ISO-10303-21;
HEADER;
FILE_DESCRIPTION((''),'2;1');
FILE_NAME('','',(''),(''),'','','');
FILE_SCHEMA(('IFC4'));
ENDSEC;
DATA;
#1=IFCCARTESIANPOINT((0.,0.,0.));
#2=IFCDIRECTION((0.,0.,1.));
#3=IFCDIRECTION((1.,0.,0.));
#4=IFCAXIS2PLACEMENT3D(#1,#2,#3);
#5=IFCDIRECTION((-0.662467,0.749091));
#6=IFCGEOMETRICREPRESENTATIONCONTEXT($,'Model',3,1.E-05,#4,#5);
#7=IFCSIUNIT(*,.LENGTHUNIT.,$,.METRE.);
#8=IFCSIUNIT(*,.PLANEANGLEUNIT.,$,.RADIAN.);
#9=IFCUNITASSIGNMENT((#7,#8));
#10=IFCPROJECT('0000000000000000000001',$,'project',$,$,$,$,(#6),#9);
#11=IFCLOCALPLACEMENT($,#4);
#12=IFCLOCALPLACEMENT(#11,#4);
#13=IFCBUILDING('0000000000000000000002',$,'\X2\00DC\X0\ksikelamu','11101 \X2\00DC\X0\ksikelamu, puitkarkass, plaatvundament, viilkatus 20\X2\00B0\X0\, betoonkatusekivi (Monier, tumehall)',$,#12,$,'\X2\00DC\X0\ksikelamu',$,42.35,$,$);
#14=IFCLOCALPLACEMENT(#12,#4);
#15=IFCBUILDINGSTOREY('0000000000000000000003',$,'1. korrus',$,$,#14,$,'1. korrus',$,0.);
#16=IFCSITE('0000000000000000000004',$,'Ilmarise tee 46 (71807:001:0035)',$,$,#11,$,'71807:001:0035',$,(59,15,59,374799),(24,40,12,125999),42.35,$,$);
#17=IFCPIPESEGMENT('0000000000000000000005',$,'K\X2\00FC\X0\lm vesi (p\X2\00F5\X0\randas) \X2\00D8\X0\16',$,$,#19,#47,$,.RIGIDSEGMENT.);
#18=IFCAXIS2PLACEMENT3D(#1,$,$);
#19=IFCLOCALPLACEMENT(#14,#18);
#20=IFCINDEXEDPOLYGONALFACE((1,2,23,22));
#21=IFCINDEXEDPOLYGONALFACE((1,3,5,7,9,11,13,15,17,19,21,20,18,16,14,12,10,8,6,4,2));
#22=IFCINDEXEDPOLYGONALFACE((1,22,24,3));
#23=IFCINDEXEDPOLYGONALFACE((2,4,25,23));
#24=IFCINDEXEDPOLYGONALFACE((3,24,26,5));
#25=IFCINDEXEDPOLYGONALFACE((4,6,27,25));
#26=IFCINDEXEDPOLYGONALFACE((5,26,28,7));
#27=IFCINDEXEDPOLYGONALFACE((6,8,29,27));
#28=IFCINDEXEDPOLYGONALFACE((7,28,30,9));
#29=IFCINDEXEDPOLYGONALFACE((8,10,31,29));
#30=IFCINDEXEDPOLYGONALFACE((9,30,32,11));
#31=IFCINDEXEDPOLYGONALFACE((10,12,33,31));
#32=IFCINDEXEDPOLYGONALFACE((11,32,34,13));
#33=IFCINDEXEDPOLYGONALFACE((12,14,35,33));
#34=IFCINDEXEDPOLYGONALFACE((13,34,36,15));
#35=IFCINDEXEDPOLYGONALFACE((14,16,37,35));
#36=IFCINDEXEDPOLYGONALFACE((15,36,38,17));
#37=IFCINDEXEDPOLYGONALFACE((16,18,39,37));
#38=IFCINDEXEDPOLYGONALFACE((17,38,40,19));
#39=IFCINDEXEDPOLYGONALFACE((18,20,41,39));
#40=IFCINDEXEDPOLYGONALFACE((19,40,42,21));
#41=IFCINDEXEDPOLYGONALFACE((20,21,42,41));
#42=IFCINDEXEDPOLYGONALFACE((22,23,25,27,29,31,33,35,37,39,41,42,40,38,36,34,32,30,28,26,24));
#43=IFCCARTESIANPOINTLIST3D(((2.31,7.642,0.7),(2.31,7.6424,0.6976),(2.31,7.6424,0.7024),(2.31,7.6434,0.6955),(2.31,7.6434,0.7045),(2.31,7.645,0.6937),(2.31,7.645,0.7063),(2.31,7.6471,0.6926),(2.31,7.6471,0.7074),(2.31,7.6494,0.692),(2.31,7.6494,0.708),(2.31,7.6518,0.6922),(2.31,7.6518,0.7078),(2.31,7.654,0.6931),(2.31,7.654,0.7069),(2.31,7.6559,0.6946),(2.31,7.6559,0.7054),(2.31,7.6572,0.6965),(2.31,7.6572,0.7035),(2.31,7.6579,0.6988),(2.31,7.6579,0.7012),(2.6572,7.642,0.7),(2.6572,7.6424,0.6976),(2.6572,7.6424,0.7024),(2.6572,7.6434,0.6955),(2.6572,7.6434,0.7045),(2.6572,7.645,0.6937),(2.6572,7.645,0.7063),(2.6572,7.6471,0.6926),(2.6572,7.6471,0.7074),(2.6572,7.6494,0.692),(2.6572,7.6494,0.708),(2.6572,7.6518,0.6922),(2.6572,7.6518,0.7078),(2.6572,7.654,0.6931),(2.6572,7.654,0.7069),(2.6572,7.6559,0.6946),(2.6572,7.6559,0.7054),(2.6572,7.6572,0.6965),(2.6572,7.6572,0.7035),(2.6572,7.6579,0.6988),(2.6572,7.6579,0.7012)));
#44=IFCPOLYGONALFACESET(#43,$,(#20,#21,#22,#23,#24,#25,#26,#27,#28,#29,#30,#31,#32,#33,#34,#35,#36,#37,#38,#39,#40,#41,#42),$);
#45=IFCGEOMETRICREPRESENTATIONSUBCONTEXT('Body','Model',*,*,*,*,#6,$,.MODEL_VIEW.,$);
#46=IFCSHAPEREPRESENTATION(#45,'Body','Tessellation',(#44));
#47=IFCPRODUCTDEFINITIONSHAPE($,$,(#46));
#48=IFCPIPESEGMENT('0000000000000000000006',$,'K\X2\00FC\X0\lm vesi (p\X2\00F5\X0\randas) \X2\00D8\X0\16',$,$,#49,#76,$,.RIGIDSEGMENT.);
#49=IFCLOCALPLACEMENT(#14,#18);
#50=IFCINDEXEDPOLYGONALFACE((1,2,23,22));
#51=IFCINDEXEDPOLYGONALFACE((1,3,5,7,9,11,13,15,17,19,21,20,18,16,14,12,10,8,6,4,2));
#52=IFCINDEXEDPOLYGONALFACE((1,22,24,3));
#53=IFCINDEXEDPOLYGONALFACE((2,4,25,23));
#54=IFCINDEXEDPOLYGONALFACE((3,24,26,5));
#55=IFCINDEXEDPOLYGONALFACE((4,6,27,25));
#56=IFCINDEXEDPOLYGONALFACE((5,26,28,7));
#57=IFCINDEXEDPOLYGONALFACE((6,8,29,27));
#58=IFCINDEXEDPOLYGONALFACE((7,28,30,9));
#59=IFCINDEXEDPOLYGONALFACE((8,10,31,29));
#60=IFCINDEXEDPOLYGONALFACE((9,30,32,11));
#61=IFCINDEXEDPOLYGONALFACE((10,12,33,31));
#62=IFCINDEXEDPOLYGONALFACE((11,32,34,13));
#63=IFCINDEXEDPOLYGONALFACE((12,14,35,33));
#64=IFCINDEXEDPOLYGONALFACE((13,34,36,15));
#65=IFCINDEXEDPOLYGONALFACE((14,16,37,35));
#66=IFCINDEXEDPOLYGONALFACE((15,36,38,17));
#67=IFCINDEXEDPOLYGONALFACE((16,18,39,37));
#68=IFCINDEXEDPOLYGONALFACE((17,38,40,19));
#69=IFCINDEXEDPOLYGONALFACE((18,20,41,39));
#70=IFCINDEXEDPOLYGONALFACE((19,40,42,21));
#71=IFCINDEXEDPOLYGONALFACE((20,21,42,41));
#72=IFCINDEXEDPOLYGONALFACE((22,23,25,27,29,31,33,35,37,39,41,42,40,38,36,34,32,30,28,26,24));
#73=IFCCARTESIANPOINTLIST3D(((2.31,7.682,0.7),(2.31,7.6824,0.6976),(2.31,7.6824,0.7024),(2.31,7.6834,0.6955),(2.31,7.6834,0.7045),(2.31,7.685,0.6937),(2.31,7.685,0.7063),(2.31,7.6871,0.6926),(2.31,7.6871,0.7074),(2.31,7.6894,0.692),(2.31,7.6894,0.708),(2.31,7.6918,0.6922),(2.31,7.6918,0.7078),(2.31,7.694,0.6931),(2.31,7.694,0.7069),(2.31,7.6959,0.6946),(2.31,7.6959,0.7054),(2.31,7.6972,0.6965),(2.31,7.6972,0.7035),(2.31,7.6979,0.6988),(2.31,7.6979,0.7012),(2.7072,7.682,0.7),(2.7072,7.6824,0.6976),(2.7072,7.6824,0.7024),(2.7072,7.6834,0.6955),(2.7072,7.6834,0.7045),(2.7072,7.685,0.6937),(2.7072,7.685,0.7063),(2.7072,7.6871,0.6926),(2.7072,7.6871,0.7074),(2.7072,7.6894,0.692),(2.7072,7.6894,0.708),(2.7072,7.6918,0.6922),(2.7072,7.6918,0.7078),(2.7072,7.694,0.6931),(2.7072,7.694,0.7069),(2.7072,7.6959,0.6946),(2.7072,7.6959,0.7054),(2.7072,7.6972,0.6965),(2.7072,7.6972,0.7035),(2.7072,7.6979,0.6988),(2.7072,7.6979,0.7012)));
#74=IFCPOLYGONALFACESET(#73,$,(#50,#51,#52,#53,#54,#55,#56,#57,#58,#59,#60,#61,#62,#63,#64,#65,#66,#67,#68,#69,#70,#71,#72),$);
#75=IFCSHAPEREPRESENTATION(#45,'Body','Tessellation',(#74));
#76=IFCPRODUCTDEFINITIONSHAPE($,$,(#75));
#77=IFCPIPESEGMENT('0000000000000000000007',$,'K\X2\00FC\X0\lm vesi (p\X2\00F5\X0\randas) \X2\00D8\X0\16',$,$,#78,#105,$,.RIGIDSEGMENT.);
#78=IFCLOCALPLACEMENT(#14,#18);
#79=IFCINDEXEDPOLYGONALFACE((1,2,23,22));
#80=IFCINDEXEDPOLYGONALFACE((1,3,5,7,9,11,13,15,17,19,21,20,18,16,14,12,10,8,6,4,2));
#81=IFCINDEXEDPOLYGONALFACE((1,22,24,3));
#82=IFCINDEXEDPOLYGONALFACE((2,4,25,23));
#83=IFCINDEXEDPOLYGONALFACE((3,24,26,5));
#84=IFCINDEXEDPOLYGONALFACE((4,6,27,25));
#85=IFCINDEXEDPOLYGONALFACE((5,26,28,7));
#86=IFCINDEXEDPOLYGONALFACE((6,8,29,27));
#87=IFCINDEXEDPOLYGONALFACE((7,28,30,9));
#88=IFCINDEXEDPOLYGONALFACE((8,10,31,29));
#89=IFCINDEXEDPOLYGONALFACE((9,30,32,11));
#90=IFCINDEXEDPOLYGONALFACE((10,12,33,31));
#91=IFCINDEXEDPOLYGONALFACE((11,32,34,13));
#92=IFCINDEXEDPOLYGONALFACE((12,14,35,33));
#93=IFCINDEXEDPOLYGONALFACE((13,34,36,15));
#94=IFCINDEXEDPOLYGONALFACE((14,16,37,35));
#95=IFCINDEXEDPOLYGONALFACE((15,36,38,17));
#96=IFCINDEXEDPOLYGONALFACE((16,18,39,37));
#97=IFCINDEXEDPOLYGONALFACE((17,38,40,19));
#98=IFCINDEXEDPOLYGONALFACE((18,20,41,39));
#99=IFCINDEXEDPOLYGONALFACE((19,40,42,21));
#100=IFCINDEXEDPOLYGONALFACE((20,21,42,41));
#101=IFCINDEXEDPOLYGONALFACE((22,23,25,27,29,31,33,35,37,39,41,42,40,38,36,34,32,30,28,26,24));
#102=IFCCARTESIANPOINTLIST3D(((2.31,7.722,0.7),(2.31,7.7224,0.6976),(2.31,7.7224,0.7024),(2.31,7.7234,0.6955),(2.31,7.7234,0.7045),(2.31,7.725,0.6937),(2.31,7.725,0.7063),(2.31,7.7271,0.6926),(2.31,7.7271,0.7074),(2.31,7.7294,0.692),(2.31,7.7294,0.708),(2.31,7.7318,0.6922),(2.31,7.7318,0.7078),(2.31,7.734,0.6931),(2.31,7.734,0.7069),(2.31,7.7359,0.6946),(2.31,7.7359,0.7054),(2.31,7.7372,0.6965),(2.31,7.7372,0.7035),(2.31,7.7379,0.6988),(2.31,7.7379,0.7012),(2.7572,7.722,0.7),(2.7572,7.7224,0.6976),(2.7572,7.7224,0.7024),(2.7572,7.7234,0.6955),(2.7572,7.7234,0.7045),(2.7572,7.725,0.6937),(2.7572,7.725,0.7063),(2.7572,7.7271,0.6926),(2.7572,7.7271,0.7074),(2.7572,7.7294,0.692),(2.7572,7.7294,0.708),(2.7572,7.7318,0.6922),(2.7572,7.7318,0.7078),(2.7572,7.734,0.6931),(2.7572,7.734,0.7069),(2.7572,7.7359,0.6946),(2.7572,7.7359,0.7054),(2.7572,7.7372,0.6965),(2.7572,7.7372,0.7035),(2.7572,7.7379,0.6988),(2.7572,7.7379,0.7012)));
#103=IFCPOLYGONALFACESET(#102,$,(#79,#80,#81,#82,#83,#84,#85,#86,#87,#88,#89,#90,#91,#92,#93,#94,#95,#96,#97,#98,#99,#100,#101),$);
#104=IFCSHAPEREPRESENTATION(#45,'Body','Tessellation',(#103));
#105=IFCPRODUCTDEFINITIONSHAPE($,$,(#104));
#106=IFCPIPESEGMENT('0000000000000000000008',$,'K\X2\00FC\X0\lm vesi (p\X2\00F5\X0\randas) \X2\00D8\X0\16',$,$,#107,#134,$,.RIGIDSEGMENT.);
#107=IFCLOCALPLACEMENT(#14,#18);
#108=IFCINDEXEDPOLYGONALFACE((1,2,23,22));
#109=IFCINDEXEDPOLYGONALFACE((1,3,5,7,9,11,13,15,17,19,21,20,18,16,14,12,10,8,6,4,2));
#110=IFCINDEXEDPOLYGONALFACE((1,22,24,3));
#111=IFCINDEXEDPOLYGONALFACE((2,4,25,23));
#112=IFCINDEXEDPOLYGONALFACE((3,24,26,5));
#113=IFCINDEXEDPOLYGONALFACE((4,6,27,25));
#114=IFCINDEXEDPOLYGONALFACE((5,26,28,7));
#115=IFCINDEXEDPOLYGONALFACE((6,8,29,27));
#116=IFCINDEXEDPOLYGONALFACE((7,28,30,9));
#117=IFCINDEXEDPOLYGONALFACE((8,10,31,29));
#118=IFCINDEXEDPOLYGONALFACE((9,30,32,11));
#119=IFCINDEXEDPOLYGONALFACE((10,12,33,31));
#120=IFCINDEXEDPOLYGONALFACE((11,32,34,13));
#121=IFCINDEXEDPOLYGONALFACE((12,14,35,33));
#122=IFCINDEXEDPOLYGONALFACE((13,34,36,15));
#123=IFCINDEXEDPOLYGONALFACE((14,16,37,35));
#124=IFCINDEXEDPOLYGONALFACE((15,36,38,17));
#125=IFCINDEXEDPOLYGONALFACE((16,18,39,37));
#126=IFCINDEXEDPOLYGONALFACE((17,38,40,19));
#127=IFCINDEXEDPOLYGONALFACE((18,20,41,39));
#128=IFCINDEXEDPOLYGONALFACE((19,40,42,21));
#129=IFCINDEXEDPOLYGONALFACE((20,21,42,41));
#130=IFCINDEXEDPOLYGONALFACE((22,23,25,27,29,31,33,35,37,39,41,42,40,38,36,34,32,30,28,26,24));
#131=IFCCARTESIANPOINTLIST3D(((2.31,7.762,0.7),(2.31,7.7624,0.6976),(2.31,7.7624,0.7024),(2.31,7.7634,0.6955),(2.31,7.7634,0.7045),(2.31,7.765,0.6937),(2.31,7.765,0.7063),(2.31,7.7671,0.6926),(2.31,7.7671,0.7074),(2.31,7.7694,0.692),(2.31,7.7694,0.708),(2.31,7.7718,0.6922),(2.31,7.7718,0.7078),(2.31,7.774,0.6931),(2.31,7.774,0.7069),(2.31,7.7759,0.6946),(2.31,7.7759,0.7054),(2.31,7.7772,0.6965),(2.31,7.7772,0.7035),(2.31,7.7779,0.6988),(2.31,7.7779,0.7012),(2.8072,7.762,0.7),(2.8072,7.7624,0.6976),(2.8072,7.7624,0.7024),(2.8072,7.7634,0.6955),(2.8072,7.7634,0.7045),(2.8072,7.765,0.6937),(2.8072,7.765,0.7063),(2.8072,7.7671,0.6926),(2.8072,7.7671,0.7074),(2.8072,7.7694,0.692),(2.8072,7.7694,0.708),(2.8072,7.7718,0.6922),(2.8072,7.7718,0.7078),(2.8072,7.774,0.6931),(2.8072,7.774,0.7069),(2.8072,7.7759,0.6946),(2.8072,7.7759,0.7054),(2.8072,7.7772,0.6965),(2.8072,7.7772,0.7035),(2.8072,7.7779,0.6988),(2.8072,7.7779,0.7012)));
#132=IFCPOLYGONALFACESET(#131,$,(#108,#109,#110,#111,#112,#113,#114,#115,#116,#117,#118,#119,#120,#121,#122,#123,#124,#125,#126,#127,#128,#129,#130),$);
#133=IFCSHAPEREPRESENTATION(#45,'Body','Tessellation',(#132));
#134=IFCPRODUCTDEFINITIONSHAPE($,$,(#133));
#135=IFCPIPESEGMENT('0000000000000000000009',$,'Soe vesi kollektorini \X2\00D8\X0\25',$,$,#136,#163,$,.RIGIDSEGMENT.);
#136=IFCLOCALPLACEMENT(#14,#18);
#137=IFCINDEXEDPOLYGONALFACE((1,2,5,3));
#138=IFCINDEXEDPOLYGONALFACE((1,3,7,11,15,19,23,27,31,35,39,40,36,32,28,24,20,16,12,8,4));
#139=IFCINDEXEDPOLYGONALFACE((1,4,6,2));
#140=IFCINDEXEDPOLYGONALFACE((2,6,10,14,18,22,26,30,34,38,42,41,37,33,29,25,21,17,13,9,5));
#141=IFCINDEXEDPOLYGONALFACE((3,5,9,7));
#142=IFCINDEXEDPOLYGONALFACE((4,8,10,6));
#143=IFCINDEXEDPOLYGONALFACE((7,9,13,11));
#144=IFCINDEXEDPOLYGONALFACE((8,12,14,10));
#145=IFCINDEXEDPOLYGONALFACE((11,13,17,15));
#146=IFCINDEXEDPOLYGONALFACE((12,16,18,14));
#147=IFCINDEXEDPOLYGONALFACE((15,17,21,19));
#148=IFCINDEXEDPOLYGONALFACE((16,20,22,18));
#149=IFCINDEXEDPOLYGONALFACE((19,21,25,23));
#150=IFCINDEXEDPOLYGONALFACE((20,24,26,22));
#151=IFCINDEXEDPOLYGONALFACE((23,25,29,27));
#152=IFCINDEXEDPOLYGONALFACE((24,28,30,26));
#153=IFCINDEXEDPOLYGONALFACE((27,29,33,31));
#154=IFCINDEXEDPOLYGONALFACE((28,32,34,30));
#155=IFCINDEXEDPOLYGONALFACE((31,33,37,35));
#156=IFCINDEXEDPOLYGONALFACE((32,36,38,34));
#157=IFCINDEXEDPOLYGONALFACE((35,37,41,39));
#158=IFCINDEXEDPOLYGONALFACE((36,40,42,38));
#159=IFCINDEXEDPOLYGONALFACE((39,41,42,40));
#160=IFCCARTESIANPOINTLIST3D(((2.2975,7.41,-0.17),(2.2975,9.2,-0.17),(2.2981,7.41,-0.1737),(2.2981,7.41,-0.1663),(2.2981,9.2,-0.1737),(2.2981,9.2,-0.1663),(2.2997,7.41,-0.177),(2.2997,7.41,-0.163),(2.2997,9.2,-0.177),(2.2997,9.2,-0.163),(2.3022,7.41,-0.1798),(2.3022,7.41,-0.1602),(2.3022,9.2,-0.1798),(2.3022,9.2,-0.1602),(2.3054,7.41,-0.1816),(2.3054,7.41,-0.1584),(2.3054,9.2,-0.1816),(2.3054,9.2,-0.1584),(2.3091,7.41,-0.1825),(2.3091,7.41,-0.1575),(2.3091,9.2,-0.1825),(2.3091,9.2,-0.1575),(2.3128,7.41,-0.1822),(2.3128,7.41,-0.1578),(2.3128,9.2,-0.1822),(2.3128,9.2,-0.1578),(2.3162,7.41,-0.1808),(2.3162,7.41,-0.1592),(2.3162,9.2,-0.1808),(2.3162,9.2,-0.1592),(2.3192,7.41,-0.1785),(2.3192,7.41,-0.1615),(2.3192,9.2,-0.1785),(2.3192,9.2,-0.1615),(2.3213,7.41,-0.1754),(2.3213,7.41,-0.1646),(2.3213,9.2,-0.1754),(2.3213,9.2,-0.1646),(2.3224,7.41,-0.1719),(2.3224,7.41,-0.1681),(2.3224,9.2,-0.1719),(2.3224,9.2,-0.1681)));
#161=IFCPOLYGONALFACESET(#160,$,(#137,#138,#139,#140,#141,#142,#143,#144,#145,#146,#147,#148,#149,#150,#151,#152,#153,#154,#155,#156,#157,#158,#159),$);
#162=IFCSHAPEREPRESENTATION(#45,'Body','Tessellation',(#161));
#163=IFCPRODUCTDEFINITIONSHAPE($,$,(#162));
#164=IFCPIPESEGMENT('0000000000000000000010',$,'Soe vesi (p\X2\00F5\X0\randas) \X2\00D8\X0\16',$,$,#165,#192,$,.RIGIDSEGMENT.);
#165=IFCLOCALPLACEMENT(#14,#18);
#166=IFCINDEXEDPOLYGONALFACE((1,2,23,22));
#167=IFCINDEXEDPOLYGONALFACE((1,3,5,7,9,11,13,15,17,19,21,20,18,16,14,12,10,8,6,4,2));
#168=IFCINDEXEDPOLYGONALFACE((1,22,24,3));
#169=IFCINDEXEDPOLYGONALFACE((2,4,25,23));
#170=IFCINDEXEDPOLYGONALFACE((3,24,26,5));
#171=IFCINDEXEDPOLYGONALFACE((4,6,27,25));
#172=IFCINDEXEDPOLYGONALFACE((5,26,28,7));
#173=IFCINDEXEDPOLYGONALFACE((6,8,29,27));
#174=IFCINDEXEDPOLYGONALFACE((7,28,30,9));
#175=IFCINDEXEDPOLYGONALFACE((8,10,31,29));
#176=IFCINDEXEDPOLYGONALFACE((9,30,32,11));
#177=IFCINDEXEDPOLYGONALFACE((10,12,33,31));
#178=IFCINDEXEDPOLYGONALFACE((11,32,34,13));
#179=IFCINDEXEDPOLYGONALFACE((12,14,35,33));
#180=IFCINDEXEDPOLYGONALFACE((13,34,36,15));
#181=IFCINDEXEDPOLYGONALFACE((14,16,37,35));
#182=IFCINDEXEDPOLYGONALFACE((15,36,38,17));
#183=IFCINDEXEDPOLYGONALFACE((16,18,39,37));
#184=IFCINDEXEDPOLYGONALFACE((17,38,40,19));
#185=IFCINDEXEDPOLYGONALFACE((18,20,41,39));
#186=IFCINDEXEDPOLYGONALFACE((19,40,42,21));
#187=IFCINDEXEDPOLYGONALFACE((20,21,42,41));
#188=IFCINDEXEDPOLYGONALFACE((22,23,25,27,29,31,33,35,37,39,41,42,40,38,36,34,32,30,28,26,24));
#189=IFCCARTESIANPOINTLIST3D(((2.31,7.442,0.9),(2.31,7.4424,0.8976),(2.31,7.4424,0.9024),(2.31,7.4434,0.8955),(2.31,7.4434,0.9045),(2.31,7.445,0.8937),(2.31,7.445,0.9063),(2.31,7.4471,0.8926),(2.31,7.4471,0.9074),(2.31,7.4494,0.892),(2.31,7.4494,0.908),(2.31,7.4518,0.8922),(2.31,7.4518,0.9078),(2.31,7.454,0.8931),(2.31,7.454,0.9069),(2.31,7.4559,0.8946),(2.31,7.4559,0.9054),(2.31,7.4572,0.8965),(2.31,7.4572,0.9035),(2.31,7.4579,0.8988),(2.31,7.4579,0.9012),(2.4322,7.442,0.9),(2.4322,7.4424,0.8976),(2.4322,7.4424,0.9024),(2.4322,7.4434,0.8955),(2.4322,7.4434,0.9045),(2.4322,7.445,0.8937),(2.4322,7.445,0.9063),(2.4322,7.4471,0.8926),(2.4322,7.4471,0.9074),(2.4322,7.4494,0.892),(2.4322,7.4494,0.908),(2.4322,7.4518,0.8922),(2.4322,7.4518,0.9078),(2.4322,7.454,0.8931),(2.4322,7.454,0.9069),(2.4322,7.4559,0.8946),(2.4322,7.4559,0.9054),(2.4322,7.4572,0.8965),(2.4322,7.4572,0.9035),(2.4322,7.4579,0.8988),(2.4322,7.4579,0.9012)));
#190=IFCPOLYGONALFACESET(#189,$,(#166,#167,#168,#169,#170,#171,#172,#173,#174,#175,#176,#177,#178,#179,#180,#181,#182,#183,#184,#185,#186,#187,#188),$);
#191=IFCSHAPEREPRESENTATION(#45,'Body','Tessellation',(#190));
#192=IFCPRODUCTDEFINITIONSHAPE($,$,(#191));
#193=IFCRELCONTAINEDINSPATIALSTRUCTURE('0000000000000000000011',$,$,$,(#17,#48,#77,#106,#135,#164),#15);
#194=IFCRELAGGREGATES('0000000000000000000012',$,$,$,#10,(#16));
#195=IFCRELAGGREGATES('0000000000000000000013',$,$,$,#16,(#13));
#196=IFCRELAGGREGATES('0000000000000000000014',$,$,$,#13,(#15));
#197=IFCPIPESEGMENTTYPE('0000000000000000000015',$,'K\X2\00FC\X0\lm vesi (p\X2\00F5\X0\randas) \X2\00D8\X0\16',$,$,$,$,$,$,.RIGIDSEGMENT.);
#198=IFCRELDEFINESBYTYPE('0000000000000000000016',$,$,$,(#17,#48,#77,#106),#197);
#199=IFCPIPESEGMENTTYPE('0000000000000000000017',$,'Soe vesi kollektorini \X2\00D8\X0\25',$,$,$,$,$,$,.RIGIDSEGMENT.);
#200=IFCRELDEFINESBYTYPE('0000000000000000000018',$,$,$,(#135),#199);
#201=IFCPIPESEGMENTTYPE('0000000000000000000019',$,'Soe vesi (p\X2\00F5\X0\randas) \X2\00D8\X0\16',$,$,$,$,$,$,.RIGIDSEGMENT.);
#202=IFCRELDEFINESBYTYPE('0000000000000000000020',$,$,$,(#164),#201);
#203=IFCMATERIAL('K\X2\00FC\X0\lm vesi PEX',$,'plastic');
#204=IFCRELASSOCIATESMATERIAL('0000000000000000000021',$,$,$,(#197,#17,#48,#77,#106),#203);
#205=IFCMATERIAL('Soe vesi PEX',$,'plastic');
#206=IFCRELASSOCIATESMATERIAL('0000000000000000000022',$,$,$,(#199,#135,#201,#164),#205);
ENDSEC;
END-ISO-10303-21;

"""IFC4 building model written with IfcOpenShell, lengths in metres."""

from ifc_helpers import new_model, si_unit, direction, frame, origin_with_axes, place, context, subcontext, project, spatial, circle, extrude, material, type_object, element, save


model = new_model("IFC4")

# Units and contexts
model_context = context("Model", 3, precision=1e-05, world=origin_with_axes(), true_north=direction((-0.662467, 0.749091)))
body_context = subcontext(model_context, "Body", "Model", "MODEL_VIEW")
ifc_project = project(units=[si_unit("LENGTHUNIT", "METRE"), si_unit("PLANEANGLEUNIT", "RADIAN")], contexts=[model_context])

# Site, building, storey
site_placement = place(None, origin_with_axes())
site = spatial("IfcSite", under=ifc_project, at=site_placement, Name="Ilmarise tee 46 (71807:001:0035)", LongName="71807:001:0035", RefLatitude=(59, 15, 59, 374799), RefLongitude=(24, 40, 12, 125999), RefElevation=42.35)
building_placement = place(site_placement, origin_with_axes())
building = spatial("IfcBuilding", under=site, at=building_placement, Name="Üksikelamu", Description="11101 Üksikelamu, puitkarkass, plaatvundament, viilkatus 20°, betoonkatusekivi (Monier, tumehall)", LongName="Üksikelamu", ElevationOfRefHeight=42.35)
storey_placement = place(building_placement, origin_with_axes())
storey = spatial("IfcBuildingStorey", under=building, at=storey_placement, Name="1. korrus", LongName="1. korrus", Elevation=0.0)

# Shared definitions
ifc_material_1 = material(Name="Soe vesi PEX", Category="plastic")

# Pipe segments
ifc_material_2 = material(Name="Külm vesi PEX", Category="plastic")
pipe_segment_type_1 = type_object("IfcPipeSegmentType", Name="Külm vesi (põrandas) Ø16", PredefinedType="RIGIDSEGMENT", material=ifc_material_2)
pipe_segment_1_placement = place(storey_placement, frame((2.31, 7.65, 0.7), z_axis=(1.0, 0.0, 0.0), x_axis=(0.0, -1.0, 0.0)))
element("IfcPipeSegment", 1, at=pipe_segment_1_placement, inside=storey, type_object=pipe_segment_type_1, material=ifc_material_2, Name="Külm vesi (põrandas) Ø16", PredefinedType="RIGIDSEGMENT", context=body_context, shape_type="SweptSolid", body=[
    extrude(circle(Radius=0.008), origin_with_axes(), (0.0, 0.0, 1.0), 0.3472),
])
pipe_segment_2_placement = place(storey_placement, frame((2.31, 7.69, 0.7), z_axis=(1.0, 0.0, 0.0), x_axis=(0.0, -1.0, 0.0)))
element("IfcPipeSegment", 2, at=pipe_segment_2_placement, inside=storey, type_object=pipe_segment_type_1, material=ifc_material_2, Name="Külm vesi (põrandas) Ø16", PredefinedType="RIGIDSEGMENT", context=body_context, shape_type="SweptSolid", body=[
    extrude(circle(Radius=0.008), origin_with_axes(), (0.0, 0.0, 1.0), 0.3972),
])
pipe_segment_3_placement = place(storey_placement, frame((2.31, 7.73, 0.7), z_axis=(1.0, 0.0, 0.0), x_axis=(0.0, -1.0, 0.0)))
element("IfcPipeSegment", 3, at=pipe_segment_3_placement, inside=storey, type_object=pipe_segment_type_1, material=ifc_material_2, Name="Külm vesi (põrandas) Ø16", PredefinedType="RIGIDSEGMENT", context=body_context, shape_type="SweptSolid", body=[
    extrude(circle(Radius=0.008), origin_with_axes(), (0.0, 0.0, 1.0), 0.4472),
])
pipe_segment_4_placement = place(storey_placement, frame((2.31, 7.77, 0.7), z_axis=(1.0, 0.0, 0.0), x_axis=(0.0, -1.0, 0.0)))
element("IfcPipeSegment", 4, at=pipe_segment_4_placement, inside=storey, type_object=pipe_segment_type_1, material=ifc_material_2, Name="Külm vesi (põrandas) Ø16", PredefinedType="RIGIDSEGMENT", context=body_context, shape_type="SweptSolid", body=[
    extrude(circle(Radius=0.008), origin_with_axes(), (0.0, 0.0, 1.0), 0.4972),
])
pipe_segment_type_2 = type_object("IfcPipeSegmentType", Name="Soe vesi kollektorini Ø25", PredefinedType="RIGIDSEGMENT", material=ifc_material_1)
pipe_segment_5_placement = place(storey_placement, frame((2.31, 9.2, -0.17), z_axis=(0.0, -1.0, 0.0), x_axis=(-1.0, 0.0, 0.0)))
element("IfcPipeSegment", 5, at=pipe_segment_5_placement, inside=storey, type_object=pipe_segment_type_2, material=ifc_material_1, Name="Soe vesi kollektorini Ø25", PredefinedType="RIGIDSEGMENT", context=body_context, shape_type="SweptSolid", body=[
    extrude(circle(Radius=0.0125), origin_with_axes(), (0.0, 0.0, 1.0), 1.79),
])
pipe_segment_type_3 = type_object("IfcPipeSegmentType", Name="Soe vesi (põrandas) Ø16", PredefinedType="RIGIDSEGMENT", material=ifc_material_1)
pipe_segment_6_placement = place(storey_placement, frame((2.31, 7.45, 0.9), z_axis=(1.0, 0.0, 0.0), x_axis=(0.0, -1.0, 0.0)))
element("IfcPipeSegment", 6, at=pipe_segment_6_placement, inside=storey, type_object=pipe_segment_type_3, material=ifc_material_1, Name="Soe vesi (põrandas) Ø16", PredefinedType="RIGIDSEGMENT", context=body_context, shape_type="SweptSolid", body=[
    extrude(circle(Radius=0.008), origin_with_axes(), (0.0, 0.0, 1.0), 0.1222),
])

save(model, "model.ifc")
